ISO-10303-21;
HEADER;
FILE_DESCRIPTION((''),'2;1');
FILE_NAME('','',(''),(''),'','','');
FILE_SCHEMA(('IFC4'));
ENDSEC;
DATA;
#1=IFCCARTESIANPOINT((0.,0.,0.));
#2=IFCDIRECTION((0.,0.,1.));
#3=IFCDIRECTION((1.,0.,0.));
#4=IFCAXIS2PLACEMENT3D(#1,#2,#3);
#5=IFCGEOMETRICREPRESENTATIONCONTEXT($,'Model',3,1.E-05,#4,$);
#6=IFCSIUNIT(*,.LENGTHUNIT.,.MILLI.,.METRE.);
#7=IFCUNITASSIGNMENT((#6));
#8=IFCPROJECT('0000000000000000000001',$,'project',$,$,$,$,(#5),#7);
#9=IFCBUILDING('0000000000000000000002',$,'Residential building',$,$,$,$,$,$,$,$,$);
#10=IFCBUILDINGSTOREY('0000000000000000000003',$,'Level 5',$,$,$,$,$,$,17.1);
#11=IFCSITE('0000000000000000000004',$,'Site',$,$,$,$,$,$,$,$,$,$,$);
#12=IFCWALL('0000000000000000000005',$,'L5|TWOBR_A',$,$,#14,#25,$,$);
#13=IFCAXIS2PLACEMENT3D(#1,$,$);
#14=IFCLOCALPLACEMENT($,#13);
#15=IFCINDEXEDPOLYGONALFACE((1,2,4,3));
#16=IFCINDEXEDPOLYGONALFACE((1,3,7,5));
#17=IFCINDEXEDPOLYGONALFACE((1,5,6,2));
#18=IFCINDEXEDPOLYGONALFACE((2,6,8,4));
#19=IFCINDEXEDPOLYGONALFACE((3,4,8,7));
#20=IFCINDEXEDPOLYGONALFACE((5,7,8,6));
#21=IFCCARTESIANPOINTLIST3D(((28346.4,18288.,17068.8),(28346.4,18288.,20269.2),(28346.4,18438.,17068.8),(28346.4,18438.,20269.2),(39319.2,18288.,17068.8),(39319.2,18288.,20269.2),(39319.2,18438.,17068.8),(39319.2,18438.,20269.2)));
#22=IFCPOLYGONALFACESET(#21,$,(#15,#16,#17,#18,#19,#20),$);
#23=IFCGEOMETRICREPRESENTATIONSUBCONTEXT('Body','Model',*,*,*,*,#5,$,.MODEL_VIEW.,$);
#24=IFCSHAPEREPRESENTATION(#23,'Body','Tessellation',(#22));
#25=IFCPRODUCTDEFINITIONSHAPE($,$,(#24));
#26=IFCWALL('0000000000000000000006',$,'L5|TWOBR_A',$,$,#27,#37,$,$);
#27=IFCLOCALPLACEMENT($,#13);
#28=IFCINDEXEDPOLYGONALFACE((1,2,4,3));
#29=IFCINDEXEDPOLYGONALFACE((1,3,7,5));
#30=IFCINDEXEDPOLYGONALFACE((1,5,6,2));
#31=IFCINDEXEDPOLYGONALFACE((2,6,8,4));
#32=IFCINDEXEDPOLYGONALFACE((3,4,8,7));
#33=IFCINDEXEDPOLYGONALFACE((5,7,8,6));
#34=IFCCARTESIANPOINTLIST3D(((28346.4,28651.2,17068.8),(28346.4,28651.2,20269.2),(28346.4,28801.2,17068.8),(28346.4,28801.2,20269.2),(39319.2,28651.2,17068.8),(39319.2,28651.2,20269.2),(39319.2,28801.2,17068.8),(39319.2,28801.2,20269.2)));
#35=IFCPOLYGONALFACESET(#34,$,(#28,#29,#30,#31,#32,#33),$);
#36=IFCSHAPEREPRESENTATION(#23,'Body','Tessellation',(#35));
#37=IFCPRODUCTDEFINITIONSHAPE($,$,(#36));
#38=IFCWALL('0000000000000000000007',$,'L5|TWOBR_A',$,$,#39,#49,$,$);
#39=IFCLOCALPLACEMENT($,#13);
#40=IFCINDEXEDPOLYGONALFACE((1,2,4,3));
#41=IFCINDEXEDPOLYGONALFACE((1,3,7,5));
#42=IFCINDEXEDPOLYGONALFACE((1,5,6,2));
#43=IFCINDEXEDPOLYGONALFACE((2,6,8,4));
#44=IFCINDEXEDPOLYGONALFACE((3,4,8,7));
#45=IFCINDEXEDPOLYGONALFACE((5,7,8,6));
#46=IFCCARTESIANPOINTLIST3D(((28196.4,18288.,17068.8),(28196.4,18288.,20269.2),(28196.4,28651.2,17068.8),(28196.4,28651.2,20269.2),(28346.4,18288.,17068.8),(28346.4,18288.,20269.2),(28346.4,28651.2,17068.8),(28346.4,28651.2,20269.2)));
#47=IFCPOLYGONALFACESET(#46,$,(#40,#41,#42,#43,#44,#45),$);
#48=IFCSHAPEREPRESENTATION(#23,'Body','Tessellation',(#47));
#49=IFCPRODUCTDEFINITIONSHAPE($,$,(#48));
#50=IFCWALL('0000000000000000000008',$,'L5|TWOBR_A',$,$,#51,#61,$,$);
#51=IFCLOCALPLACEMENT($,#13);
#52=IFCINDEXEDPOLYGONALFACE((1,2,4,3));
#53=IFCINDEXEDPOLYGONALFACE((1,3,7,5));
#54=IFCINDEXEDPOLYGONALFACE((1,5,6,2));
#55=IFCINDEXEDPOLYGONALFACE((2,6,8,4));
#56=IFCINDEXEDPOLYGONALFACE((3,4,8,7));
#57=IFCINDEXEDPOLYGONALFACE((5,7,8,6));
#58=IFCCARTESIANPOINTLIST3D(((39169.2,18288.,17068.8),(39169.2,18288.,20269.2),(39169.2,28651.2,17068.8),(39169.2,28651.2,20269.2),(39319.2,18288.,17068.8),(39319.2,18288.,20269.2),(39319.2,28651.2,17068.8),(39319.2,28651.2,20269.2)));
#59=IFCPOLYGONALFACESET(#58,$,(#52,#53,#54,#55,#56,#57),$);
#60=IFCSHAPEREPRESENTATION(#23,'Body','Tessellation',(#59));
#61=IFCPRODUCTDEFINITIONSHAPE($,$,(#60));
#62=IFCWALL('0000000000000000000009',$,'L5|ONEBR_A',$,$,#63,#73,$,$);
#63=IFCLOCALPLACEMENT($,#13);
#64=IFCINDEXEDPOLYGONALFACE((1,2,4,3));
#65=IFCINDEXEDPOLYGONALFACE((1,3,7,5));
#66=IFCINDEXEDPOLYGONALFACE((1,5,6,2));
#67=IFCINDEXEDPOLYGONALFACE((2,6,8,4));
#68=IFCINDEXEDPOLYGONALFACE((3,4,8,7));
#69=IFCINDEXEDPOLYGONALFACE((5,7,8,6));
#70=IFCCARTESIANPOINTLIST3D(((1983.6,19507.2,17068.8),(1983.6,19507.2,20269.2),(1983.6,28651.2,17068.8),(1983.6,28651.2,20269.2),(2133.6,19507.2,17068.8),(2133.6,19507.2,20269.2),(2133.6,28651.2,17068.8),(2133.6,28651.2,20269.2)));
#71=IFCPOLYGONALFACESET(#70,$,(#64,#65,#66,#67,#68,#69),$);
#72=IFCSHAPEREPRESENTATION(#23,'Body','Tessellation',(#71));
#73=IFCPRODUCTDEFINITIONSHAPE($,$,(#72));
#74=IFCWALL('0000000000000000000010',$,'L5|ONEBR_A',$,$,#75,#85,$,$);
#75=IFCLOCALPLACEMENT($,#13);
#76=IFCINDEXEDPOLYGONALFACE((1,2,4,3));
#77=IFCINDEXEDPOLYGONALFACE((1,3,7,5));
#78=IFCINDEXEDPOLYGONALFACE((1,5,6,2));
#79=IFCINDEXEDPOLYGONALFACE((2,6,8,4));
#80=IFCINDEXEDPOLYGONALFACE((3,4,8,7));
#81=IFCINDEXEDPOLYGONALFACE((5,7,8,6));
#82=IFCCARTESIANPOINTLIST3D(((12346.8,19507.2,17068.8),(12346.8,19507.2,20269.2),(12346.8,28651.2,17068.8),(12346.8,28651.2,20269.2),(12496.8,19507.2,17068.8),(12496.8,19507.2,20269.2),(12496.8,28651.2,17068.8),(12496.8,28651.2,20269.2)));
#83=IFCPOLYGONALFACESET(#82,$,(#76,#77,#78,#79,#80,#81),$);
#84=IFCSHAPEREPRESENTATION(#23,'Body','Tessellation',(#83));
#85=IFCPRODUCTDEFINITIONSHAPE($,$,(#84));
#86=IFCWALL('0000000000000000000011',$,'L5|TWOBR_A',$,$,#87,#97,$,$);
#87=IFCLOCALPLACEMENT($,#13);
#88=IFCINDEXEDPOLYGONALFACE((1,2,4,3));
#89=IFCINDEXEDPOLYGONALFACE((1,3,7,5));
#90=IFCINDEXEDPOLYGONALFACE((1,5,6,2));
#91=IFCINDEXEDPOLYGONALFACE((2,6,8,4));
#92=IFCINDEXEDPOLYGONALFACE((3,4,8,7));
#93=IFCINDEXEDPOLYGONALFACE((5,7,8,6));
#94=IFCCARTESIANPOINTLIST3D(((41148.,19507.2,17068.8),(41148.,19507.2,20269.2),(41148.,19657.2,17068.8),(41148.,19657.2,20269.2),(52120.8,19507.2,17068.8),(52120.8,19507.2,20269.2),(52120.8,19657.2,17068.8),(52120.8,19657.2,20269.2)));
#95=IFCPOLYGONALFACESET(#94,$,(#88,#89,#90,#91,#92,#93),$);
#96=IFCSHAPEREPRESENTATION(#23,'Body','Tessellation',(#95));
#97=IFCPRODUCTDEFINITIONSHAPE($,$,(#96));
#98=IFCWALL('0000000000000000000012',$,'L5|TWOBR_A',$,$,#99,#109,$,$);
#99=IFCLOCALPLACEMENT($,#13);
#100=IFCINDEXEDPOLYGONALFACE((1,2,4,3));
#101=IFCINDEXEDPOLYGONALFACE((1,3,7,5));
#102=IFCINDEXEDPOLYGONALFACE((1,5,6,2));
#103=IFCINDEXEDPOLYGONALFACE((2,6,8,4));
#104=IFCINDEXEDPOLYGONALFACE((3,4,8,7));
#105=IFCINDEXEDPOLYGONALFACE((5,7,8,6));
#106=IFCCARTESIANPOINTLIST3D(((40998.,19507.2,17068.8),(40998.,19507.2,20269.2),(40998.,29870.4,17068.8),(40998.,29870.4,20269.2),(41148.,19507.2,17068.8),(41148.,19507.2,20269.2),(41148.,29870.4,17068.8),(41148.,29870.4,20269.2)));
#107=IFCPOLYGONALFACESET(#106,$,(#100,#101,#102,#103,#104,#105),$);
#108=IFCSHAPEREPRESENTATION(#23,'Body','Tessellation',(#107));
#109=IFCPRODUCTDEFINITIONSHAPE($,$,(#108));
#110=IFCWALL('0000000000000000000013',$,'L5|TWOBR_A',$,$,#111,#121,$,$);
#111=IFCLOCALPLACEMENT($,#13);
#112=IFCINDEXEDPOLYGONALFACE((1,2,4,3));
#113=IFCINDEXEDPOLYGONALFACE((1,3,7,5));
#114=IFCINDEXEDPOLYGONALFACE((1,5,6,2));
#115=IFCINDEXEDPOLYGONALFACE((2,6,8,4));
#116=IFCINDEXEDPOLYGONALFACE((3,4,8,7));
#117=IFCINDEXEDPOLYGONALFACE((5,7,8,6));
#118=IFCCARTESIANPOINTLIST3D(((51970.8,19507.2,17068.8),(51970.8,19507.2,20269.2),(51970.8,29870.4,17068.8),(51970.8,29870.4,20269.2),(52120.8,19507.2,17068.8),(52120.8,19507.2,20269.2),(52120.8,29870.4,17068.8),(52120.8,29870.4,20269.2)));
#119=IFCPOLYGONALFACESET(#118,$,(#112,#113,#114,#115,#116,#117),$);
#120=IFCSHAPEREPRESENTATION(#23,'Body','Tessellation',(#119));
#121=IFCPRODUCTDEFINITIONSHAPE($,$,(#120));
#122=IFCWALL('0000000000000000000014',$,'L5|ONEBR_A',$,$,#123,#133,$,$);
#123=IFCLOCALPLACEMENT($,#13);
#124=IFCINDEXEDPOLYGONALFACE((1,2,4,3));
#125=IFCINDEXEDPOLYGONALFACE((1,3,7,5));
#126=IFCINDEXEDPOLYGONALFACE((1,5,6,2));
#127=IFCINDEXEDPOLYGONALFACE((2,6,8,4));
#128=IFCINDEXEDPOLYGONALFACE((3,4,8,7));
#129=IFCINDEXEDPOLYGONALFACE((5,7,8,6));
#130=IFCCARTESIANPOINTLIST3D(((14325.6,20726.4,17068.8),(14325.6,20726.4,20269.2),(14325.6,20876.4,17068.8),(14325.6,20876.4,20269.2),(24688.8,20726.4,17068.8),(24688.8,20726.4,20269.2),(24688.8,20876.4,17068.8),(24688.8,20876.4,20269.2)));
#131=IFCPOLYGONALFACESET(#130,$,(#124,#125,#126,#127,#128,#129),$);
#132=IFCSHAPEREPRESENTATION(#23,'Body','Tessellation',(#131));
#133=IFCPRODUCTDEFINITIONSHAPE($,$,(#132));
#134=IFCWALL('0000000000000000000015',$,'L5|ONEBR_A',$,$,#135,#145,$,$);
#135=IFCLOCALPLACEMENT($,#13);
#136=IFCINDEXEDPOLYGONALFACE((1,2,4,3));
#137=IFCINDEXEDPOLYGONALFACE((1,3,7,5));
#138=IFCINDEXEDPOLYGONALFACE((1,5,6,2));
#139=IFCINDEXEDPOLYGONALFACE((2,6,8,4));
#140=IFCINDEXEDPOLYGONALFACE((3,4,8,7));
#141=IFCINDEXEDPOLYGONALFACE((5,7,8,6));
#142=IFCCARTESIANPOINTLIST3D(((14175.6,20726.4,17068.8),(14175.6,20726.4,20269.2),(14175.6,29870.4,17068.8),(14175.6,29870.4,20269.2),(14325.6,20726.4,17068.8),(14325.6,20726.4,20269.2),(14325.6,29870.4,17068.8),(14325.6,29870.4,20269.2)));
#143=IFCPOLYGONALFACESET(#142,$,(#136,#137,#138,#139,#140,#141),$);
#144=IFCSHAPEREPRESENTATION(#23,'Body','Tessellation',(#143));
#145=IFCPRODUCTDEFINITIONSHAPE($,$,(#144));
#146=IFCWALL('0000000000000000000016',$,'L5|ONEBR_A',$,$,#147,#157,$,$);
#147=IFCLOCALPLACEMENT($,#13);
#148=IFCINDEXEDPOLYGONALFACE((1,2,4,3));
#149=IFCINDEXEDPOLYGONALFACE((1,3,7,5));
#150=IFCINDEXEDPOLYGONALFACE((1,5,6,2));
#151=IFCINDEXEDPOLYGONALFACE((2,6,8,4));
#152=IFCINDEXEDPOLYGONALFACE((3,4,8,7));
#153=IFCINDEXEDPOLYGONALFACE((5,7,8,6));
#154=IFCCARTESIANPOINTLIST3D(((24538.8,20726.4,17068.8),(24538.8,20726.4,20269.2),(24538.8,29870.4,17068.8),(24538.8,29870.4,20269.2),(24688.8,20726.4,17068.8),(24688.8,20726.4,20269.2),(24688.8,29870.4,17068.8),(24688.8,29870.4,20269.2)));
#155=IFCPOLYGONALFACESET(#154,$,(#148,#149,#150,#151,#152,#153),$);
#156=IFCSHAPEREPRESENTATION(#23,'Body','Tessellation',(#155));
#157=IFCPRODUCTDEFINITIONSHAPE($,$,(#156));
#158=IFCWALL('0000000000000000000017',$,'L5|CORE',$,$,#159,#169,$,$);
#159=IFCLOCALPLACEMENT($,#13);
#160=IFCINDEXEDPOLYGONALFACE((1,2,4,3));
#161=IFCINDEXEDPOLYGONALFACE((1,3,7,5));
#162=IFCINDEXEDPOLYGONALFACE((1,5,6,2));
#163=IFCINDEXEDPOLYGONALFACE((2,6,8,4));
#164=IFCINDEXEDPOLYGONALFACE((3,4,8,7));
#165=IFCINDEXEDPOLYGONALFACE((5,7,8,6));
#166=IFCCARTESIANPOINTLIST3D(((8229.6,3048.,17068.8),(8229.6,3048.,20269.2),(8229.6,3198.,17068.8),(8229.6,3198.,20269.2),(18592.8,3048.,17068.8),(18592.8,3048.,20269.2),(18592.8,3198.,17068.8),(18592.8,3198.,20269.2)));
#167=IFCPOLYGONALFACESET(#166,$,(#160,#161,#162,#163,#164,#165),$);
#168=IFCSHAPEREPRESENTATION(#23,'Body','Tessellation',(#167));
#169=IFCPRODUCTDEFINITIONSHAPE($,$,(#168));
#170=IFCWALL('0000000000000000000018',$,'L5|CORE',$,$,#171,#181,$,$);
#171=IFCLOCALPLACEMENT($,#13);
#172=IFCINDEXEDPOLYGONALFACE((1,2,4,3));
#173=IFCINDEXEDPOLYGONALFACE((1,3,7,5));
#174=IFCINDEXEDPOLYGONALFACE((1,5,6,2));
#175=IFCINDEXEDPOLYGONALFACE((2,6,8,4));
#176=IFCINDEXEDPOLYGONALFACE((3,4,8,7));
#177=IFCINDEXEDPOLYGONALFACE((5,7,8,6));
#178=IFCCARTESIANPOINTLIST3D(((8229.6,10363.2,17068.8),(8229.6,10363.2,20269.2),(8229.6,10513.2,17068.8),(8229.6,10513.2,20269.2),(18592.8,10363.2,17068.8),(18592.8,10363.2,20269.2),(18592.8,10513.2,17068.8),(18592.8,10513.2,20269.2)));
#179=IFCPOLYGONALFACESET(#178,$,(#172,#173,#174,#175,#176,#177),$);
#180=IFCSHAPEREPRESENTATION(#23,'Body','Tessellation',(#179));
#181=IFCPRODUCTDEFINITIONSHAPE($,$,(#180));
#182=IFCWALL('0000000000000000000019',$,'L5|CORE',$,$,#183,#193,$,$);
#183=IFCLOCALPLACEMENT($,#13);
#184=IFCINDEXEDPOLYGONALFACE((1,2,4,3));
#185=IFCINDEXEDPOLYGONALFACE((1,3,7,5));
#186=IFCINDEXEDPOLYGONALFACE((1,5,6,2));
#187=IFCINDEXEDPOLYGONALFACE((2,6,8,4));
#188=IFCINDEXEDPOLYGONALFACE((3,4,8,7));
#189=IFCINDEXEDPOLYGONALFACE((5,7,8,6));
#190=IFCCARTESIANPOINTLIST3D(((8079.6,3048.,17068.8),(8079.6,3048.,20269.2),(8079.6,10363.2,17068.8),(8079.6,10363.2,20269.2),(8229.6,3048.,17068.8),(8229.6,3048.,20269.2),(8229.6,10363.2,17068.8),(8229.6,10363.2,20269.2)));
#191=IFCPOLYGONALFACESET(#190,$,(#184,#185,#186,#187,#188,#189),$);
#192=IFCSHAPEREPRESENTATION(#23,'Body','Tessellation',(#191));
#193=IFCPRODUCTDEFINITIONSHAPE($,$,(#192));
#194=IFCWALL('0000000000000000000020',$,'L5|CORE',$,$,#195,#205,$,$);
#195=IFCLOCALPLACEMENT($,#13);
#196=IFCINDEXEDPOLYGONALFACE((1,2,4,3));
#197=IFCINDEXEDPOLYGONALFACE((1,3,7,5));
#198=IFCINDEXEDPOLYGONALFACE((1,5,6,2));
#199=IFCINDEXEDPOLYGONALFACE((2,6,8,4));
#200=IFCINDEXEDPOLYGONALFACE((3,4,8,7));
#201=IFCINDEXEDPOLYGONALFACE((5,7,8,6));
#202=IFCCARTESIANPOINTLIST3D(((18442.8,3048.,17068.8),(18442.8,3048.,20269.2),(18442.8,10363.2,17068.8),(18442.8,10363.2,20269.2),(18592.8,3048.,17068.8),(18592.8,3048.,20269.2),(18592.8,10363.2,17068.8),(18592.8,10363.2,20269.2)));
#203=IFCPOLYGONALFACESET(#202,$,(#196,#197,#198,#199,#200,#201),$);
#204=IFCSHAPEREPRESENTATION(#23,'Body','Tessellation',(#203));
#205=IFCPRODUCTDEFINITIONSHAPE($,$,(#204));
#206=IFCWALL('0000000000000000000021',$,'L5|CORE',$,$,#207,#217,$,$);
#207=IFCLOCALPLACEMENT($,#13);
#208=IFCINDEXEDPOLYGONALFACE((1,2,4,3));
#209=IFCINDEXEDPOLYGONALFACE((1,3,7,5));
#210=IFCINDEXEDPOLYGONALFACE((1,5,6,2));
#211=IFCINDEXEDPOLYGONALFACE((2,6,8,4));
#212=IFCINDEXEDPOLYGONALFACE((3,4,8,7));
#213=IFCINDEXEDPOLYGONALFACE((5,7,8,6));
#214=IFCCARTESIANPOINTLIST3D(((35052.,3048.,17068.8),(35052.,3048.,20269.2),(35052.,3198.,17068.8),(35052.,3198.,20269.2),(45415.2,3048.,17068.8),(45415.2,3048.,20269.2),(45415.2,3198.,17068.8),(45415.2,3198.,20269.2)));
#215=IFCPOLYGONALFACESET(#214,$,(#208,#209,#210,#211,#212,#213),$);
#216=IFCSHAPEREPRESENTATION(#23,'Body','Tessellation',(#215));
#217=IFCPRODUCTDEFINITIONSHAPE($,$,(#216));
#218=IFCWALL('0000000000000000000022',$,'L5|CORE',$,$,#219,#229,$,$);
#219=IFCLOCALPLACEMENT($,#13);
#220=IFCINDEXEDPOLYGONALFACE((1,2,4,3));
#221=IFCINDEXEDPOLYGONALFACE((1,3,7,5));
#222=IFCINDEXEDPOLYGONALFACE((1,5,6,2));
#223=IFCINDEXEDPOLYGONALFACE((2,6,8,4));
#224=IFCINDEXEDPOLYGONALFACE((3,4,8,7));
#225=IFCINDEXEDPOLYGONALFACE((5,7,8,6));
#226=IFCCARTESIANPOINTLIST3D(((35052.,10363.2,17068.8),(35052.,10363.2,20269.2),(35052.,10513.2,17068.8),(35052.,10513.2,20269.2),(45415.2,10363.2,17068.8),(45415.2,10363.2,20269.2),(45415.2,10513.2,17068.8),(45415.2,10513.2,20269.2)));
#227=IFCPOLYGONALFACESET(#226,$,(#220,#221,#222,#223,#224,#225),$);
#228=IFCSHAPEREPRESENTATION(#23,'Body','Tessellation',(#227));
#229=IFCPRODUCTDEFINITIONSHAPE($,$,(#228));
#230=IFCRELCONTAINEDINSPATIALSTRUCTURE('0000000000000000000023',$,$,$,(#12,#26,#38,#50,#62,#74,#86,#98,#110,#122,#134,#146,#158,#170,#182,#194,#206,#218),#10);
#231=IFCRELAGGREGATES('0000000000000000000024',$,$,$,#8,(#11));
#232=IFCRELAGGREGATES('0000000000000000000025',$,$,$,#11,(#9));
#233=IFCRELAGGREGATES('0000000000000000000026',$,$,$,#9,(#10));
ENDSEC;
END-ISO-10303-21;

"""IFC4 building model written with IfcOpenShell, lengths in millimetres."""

from ifc_helpers import new_model, si_unit, frame, origin_with_axes, place, context, subcontext, project, spatial, indexed_curve, outline, extrude, element, save


model = new_model("IFC4")

# Units and contexts
model_context = context("Model", 3, precision=1e-05, world=origin_with_axes())
body_context = subcontext(model_context, "Body", "Model", "MODEL_VIEW")
ifc_project = project(units=[si_unit("LENGTHUNIT", "METRE", prefix="MILLI")], contexts=[model_context])

# Site, building, storey
site = spatial("IfcSite", under=ifc_project, Name="Site")
building = spatial("IfcBuilding", under=site, Name="Residential building")
storey = spatial("IfcBuildingStorey", under=building, Name="Level 5", Elevation=17.1)

# Walls
for number, where, z_axis, x_axis, name in (
    (1, (28346.4, 18288.0, 17068.8), (0.0, 0.0, 1.0), (1.0, 0.0, 0.0), "L5|TWOBR_A"),
    (2, (28346.4, 28651.2, 17068.8), (0.0, 0.0, 1.0), (1.0, 0.0, 0.0), "L5|TWOBR_A"),
):
    element("IfcWall", number, at=place(None, frame(where, z_axis=z_axis, x_axis=x_axis)), inside=storey, Name=name, context=body_context, shape_type="SweptSolid", body=[
        extrude(outline(indexed_curve([(0.0, 0.0), (0.0, 150.0), (10972.8, 150.0), (10972.8, 0.0), (0.0, 0.0)], self_intersect=False)), origin_with_axes(), (0.0, 0.0, 1.0), 3200.4),
    ])
for number, where, z_axis, x_axis, name in (
    (3, (28346.4, 18288.0, 17068.8), (0.0, 0.0, 1.0), (0.0, 1.0, 0.0), "L5|TWOBR_A"),
    (4, (39319.2, 18288.0, 17068.8), (0.0, 0.0, 1.0), (0.0, 1.0, 0.0), "L5|TWOBR_A"),
):
    element("IfcWall", number, at=place(None, frame(where, z_axis=z_axis, x_axis=x_axis)), inside=storey, Name=name, context=body_context, shape_type="SweptSolid", body=[
        extrude(outline(indexed_curve([(0.0, 0.0), (0.0, 150.0), (10363.2, 150.0), (10363.2, 0.0), (0.0, 0.0)], self_intersect=False)), origin_with_axes(), (0.0, 0.0, 1.0), 3200.4),
    ])
for number, where, z_axis, x_axis, name in (
    (5, (2133.6, 19507.2, 17068.8), (0.0, 0.0, 1.0), (0.0, 1.0, 0.0), "L5|ONEBR_A"),
    (6, (12496.8, 19507.2, 17068.8), (0.0, 0.0, 1.0), (0.0, 1.0, 0.0), "L5|ONEBR_A"),
):
    element("IfcWall", number, at=place(None, frame(where, z_axis=z_axis, x_axis=x_axis)), inside=storey, Name=name, context=body_context, shape_type="SweptSolid", body=[
        extrude(outline(indexed_curve([(0.0, 0.0), (0.0, 150.0), (9144.0, 150.0), (9144.0, 0.0), (0.0, 0.0)], self_intersect=False)), origin_with_axes(), (0.0, 0.0, 1.0), 3200.4),
    ])
wall_placement = place(None, frame((41148.0, 19507.2, 17068.8), z_axis=(0.0, 0.0, 1.0), x_axis=(1.0, 0.0, 0.0)))
element("IfcWall", 7, at=wall_placement, inside=storey, Name="L5|TWOBR_A", context=body_context, shape_type="SweptSolid", body=[
    extrude(outline(indexed_curve([(0.0, 0.0), (0.0, 150.0), (10972.8, 150.0), (10972.8, 0.0), (0.0, 0.0)], self_intersect=False)), origin_with_axes(), (0.0, 0.0, 1.0), 3200.4),
])
for number, where, z_axis, x_axis, name in (
    (8, (41148.0, 19507.2, 17068.8), (0.0, 0.0, 1.0), (0.0, 1.0, 0.0), "L5|TWOBR_A"),
    (9, (52120.8, 19507.2, 17068.8), (0.0, 0.0, 1.0), (0.0, 1.0, 0.0), "L5|TWOBR_A"),
    (10, (14325.6, 20726.4, 17068.8), (0.0, 0.0, 1.0), (1.0, 0.0, 0.0), "L5|ONEBR_A"),
):
    element("IfcWall", number, at=place(None, frame(where, z_axis=z_axis, x_axis=x_axis)), inside=storey, Name=name, context=body_context, shape_type="SweptSolid", body=[
        extrude(outline(indexed_curve([(0.0, 0.0), (0.0, 150.0), (10363.2, 150.0), (10363.2, 0.0), (0.0, 0.0)], self_intersect=False)), origin_with_axes(), (0.0, 0.0, 1.0), 3200.4),
    ])
for number, where, z_axis, x_axis, name in (
    (11, (14325.6, 20726.4, 17068.8), (0.0, 0.0, 1.0), (0.0, 1.0, 0.0), "L5|ONEBR_A"),
    (12, (24688.8, 20726.4, 17068.8), (0.0, 0.0, 1.0), (0.0, 1.0, 0.0), "L5|ONEBR_A"),
):
    element("IfcWall", number, at=place(None, frame(where, z_axis=z_axis, x_axis=x_axis)), inside=storey, Name=name, context=body_context, shape_type="SweptSolid", body=[
        extrude(outline(indexed_curve([(0.0, 0.0), (0.0, 150.0), (9144.0, 150.0), (9144.0, 0.0), (0.0, 0.0)], self_intersect=False)), origin_with_axes(), (0.0, 0.0, 1.0), 3200.4),
    ])
for number, where, z_axis, x_axis, name in (
    (13, (8229.6, 3048.0, 17068.8), (0.0, 0.0, 1.0), (1.0, 0.0, 0.0), "L5|CORE"),
    (14, (8229.6, 10363.2, 17068.8), (0.0, 0.0, 1.0), (1.0, 0.0, 0.0), "L5|CORE"),
):
    element("IfcWall", number, at=place(None, frame(where, z_axis=z_axis, x_axis=x_axis)), inside=storey, Name=name, context=body_context, shape_type="SweptSolid", body=[
        extrude(outline(indexed_curve([(0.0, 0.0), (0.0, 150.0), (10363.2, 150.0), (10363.2, 0.0), (0.0, 0.0)], self_intersect=False)), origin_with_axes(), (0.0, 0.0, 1.0), 3200.4),
    ])
for number, where, z_axis, x_axis, name in (
    (15, (8229.6, 3048.0, 17068.8), (0.0, 0.0, 1.0), (0.0, 1.0, 0.0), "L5|CORE"),
    (16, (18592.8, 3048.0, 17068.8), (0.0, 0.0, 1.0), (0.0, 1.0, 0.0), "L5|CORE"),
):
    element("IfcWall", number, at=place(None, frame(where, z_axis=z_axis, x_axis=x_axis)), inside=storey, Name=name, context=body_context, shape_type="SweptSolid", body=[
        extrude(outline(indexed_curve([(0.0, 0.0), (0.0, 150.0), (7315.2, 150.0), (7315.2, 0.0), (0.0, 0.0)], self_intersect=False)), origin_with_axes(), (0.0, 0.0, 1.0), 3200.4),
    ])
for number, where, z_axis, x_axis, name in (
    (17, (35052.0, 3048.0, 17068.8), (0.0, 0.0, 1.0), (1.0, 0.0, 0.0), "L5|CORE"),
    (18, (35052.0, 10363.2, 17068.8), (0.0, 0.0, 1.0), (1.0, 0.0, 0.0), "L5|CORE"),
):
    element("IfcWall", number, at=place(None, frame(where, z_axis=z_axis, x_axis=x_axis)), inside=storey, Name=name, context=body_context, shape_type="SweptSolid", body=[
        extrude(outline(indexed_curve([(0.0, 0.0), (0.0, 150.0), (10363.2, 150.0), (10363.2, 0.0), (0.0, 0.0)], self_intersect=False)), origin_with_axes(), (0.0, 0.0, 1.0), 3200.4),
    ])

save(model, "model.ifc")
